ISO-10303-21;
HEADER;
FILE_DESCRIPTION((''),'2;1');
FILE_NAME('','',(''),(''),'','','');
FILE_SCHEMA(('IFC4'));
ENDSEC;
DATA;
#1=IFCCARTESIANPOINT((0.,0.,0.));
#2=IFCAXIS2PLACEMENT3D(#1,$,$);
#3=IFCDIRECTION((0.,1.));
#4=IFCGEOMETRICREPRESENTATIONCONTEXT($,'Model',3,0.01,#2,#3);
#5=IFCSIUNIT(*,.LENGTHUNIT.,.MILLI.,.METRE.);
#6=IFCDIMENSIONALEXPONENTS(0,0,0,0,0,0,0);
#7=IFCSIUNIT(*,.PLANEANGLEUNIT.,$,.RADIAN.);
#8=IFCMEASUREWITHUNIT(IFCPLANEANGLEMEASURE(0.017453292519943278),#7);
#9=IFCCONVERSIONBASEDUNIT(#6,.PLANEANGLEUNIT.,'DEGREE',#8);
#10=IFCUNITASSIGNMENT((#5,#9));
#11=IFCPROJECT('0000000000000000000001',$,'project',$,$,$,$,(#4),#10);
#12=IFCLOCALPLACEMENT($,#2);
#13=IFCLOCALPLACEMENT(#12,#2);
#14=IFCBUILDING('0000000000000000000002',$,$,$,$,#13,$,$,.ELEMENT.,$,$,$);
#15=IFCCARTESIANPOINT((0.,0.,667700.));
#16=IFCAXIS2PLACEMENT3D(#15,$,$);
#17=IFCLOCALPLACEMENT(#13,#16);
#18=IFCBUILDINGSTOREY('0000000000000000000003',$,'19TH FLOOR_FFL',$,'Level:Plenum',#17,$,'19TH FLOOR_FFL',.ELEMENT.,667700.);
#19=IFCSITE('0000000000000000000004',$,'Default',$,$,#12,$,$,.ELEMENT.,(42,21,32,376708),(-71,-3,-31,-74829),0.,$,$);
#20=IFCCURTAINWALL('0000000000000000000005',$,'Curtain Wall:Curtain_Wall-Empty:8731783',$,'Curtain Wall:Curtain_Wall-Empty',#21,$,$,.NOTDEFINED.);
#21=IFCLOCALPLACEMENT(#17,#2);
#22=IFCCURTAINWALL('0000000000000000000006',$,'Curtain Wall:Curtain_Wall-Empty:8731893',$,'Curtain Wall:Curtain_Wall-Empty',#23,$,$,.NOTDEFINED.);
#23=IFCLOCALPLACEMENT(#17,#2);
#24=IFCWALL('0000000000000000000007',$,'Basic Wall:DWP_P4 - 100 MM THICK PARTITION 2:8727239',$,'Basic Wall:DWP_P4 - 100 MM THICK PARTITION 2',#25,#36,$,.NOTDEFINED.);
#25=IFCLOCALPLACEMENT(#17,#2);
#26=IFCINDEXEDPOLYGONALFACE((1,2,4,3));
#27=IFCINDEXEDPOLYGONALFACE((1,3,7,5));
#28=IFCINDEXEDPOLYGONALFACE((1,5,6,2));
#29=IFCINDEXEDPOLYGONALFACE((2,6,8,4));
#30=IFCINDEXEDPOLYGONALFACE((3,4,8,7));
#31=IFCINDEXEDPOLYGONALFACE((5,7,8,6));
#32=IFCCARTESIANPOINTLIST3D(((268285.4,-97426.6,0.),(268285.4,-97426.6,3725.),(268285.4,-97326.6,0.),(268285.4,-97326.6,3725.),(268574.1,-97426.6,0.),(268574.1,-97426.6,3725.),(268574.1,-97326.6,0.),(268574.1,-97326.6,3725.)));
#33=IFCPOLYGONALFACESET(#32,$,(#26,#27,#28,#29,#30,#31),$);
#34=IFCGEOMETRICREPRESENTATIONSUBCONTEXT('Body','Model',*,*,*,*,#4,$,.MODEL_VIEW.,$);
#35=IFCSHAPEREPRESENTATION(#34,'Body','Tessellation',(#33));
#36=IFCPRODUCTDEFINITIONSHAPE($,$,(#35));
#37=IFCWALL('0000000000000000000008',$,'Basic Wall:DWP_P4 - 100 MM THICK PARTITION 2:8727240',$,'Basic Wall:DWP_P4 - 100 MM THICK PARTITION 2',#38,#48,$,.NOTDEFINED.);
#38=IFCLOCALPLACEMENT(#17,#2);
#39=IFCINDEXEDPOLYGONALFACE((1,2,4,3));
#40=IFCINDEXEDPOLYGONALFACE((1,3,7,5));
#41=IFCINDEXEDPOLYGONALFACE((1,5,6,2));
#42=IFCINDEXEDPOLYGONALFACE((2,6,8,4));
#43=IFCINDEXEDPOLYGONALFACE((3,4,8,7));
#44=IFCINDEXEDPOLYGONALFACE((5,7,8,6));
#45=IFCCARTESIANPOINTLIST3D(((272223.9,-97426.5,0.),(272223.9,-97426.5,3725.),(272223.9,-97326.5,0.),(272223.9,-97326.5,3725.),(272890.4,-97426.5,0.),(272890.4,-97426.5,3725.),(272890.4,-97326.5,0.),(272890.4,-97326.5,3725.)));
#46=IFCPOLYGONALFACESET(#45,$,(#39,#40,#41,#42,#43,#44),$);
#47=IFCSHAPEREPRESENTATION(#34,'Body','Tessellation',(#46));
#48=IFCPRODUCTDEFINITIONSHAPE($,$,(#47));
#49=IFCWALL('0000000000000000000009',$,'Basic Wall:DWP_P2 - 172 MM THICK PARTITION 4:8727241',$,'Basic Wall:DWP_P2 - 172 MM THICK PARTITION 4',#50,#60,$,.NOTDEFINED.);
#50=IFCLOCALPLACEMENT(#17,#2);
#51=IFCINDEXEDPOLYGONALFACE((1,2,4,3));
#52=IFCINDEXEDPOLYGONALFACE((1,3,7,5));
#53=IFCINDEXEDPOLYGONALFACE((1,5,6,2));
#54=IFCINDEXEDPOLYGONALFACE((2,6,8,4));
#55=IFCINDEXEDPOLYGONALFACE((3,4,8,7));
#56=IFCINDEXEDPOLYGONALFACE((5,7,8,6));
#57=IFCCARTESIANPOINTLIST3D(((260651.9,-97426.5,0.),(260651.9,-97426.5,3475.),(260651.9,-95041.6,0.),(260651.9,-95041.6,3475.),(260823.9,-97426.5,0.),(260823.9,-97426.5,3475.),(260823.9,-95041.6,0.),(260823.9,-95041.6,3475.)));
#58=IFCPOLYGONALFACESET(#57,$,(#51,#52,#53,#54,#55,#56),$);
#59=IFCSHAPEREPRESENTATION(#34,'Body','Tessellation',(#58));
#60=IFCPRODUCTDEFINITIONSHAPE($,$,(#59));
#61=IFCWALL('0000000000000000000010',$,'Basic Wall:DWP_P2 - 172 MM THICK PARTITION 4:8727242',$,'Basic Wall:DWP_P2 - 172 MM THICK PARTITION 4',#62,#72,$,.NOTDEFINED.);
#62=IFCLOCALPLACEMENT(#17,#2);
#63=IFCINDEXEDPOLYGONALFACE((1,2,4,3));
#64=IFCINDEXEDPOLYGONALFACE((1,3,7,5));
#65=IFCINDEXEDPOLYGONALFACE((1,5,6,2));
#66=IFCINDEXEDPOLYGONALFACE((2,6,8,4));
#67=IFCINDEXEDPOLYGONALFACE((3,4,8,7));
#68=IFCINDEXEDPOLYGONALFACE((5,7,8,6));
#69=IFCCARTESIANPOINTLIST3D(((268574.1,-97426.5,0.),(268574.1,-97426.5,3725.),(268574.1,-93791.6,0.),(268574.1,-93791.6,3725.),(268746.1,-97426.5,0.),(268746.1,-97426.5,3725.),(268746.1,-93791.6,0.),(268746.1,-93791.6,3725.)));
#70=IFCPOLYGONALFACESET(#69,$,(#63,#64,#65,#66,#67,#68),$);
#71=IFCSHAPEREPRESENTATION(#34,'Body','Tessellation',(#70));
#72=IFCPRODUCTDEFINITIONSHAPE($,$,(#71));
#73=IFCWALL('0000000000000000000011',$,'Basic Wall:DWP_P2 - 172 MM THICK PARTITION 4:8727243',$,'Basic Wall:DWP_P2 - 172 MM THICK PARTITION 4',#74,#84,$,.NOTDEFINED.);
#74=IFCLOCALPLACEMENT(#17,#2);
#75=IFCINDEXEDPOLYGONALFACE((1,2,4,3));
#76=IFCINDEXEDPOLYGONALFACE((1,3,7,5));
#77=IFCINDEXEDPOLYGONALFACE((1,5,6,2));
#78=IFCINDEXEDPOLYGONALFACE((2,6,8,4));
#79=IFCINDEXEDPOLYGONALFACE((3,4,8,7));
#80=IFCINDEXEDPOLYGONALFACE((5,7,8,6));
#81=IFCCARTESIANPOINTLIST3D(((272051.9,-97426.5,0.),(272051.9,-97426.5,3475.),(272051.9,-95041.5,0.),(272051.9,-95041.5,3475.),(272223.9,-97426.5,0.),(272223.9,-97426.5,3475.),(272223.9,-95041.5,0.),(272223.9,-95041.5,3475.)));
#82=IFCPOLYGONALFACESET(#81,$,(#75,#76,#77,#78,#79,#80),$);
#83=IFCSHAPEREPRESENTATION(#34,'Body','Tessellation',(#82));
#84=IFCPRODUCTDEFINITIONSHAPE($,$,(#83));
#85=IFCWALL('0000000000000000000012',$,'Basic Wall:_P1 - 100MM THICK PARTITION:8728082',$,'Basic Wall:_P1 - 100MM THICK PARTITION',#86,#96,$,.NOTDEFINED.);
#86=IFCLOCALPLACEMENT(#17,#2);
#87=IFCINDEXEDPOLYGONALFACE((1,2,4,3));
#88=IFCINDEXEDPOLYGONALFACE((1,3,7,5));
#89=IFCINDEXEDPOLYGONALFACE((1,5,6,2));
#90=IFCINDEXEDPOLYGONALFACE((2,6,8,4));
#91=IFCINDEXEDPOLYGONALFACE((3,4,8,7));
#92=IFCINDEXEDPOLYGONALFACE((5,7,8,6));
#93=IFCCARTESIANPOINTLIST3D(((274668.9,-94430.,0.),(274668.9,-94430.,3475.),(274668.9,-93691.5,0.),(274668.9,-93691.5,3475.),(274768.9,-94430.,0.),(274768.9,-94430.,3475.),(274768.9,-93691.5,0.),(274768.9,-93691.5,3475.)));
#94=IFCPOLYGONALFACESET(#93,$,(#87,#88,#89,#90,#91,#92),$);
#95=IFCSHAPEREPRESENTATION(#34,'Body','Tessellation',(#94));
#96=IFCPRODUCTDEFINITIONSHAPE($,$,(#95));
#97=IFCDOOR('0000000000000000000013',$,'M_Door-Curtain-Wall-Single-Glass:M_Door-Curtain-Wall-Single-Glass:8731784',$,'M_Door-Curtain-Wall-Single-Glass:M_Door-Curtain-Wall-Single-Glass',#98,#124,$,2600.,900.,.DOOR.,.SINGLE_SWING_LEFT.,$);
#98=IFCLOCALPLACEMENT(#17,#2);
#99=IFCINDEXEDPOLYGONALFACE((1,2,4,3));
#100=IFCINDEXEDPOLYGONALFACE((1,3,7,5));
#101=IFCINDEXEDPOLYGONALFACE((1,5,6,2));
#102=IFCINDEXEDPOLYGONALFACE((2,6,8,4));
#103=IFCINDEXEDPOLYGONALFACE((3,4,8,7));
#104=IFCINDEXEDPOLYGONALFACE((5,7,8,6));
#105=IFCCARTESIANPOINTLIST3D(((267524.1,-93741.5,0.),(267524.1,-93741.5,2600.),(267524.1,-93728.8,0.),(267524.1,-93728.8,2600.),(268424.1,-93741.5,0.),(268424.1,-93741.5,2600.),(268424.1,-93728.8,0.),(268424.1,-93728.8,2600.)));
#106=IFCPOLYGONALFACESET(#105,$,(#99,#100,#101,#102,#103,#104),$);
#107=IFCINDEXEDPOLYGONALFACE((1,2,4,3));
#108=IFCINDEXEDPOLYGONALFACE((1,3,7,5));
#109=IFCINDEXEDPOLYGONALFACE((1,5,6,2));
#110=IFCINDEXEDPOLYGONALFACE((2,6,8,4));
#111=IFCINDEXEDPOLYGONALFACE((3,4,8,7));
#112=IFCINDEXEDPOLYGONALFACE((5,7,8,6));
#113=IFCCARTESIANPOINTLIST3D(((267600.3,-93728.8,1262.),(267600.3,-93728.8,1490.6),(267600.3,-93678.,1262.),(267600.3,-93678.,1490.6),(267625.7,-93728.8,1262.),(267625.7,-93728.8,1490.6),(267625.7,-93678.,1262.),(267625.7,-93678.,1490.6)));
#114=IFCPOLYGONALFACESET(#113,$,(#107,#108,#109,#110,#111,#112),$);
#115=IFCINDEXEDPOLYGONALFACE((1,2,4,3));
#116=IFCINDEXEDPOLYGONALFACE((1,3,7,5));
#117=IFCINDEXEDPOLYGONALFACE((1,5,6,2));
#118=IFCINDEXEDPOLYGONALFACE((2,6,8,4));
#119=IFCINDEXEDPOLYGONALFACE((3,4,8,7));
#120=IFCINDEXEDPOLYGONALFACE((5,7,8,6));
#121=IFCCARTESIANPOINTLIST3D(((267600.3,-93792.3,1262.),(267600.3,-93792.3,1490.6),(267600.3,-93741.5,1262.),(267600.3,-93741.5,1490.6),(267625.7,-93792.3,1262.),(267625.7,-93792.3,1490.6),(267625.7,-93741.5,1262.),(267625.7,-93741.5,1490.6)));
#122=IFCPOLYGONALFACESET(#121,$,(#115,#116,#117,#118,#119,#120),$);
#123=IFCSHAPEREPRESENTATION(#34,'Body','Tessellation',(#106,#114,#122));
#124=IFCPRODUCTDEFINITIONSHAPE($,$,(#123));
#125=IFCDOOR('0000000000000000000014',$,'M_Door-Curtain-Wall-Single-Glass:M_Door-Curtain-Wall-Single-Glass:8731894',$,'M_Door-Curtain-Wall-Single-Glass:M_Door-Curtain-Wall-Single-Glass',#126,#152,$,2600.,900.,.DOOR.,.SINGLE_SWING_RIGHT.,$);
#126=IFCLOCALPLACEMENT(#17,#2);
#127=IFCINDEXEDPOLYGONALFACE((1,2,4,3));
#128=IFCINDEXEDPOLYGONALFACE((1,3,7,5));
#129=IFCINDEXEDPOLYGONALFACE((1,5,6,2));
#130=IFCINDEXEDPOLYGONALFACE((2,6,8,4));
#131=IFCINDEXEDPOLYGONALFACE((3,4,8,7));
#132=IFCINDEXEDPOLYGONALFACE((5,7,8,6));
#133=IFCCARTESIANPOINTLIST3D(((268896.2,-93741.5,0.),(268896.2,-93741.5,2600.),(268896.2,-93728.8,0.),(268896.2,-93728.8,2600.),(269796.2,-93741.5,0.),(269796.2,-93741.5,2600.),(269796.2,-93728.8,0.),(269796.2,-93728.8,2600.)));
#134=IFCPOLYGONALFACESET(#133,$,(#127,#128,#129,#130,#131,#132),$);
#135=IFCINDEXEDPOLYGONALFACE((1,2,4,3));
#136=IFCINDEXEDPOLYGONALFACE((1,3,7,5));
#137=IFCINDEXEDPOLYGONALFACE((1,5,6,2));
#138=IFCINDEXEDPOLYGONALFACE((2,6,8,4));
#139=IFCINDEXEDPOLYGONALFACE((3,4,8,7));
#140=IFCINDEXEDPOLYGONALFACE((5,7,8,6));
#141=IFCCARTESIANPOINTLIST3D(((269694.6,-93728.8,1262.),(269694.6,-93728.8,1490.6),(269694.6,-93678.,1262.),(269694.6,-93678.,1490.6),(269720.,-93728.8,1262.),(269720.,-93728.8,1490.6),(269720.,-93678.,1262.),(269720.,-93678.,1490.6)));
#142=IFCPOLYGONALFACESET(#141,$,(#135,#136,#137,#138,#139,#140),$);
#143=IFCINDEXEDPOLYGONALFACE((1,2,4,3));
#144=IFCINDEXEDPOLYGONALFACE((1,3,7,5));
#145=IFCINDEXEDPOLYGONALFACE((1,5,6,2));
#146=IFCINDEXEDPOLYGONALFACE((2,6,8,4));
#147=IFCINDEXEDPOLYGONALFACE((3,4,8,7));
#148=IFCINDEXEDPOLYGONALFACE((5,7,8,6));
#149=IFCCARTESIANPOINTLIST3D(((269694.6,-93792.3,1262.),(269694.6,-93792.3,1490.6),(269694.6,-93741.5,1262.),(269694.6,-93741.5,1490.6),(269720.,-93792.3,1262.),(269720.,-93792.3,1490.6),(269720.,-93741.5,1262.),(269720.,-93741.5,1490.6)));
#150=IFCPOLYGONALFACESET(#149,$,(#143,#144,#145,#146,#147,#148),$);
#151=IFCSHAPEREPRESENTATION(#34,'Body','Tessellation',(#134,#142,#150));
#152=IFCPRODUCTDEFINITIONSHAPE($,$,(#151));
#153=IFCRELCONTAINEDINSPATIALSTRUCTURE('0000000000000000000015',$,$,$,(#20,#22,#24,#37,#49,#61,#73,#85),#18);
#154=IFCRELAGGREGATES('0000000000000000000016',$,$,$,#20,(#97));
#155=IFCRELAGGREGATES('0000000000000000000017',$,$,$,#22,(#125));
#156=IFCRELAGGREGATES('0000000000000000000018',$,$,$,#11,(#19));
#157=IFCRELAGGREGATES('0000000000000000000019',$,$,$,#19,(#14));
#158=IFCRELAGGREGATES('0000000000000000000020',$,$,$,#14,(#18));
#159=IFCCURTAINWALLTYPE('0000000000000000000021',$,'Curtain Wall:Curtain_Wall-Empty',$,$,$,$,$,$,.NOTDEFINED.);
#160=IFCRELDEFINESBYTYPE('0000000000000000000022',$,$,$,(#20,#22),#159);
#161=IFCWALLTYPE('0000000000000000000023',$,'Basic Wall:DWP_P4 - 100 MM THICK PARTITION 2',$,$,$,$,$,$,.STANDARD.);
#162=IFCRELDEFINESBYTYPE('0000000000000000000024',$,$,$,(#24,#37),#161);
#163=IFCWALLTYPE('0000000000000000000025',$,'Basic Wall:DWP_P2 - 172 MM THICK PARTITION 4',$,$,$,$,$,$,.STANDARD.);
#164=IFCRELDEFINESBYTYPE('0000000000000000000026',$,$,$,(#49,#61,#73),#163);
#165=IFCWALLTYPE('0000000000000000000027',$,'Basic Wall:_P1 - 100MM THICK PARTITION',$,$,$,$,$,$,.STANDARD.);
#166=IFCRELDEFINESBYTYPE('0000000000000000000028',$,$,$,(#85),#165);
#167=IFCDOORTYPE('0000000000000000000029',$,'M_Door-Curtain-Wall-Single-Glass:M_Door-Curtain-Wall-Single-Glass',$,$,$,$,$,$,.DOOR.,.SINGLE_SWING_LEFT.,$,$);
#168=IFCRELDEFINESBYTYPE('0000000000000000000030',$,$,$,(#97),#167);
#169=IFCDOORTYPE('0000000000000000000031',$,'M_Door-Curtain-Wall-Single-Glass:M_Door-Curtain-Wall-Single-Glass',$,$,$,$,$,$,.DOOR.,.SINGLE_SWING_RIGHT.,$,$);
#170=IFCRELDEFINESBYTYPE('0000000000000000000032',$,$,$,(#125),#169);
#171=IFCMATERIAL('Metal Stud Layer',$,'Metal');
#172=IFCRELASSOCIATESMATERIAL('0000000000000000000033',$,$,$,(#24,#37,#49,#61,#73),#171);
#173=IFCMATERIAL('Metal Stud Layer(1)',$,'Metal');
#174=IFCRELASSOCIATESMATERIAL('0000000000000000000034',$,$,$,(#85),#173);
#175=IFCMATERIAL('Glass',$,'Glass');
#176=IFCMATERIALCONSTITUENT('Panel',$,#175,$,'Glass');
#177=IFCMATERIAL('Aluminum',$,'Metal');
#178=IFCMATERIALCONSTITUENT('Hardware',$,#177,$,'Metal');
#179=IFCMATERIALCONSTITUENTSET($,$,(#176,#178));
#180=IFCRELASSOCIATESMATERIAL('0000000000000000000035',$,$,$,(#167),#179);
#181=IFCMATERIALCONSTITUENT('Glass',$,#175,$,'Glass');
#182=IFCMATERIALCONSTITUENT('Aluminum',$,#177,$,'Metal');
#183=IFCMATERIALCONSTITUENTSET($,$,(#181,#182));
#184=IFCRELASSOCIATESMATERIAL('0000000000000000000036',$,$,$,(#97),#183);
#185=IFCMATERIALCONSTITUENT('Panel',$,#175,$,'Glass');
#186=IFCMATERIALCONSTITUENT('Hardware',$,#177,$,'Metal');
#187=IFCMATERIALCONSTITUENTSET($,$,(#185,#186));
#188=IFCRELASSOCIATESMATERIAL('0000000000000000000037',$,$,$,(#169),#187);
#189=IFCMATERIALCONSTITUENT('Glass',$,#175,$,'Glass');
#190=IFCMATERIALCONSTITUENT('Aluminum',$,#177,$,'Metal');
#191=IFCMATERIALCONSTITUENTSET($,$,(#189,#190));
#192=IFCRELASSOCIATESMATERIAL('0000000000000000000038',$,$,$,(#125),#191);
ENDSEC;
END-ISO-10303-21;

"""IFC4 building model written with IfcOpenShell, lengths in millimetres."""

from ifc_helpers import new_model, entity, si_unit, converted_unit, direction, frame, origin, place, context, subcontext, project, spatial, indexed_curve, outline, extrude, source, transform, mapped, material, constituent, constituent_set, type_object, type_shapes, element, aggregate, save


model = new_model("IFC4")

# Units and contexts
model_context = context("Model", 3, precision=0.01, world=origin(), true_north=direction((0.0, 1.0)))
body_context = subcontext(model_context, "Body", "Model", "MODEL_VIEW")
ifc_project = project(units=[si_unit("LENGTHUNIT", "METRE", prefix="MILLI"), converted_unit("PLANEANGLEUNIT", "DEGREE", entity("IfcPlaneAngleMeasure", 0.017453292519943278), si_unit("PLANEANGLEUNIT", "RADIAN"), dimensions=[0, 0, 0, 0, 0, 0, 0])], contexts=[model_context])

# Site, building, storey
site_placement = place(None, origin())
site = spatial("IfcSite", under=ifc_project, at=site_placement, Name="Default", CompositionType="ELEMENT", RefLatitude=(42, 21, 32, 376708), RefLongitude=(-71, -3, -31, -74829), RefElevation=0.0)
building_placement = place(site_placement, origin())
building = spatial("IfcBuilding", under=site, at=building_placement, CompositionType="ELEMENT")
storey_placement = place(building_placement, frame((0.0, 0.0, 667700.0)))
storey = spatial("IfcBuildingStorey", under=building, at=storey_placement, Name="19TH FLOOR_FFL", ObjectType="Level:Plenum", LongName="19TH FLOOR_FFL", CompositionType="ELEMENT", Elevation=667700.0)

# Curtain walls
curtain_wall_type = type_object("IfcCurtainWallType", Name="Curtain Wall:Curtain_Wall-Empty", PredefinedType="NOTDEFINED")
curtain_wall_1_placement = place(storey_placement, frame((0.0, 0.0, -667700.0)))
curtain_wall_1 = element("IfcCurtainWall", 1, at=curtain_wall_1_placement, inside=storey, type_object=curtain_wall_type, Name="Curtain Wall:Curtain_Wall-Empty:8731783", ObjectType="Curtain Wall:Curtain_Wall-Empty", PredefinedType="NOTDEFINED")
curtain_wall_2_placement = place(storey_placement, frame((0.0, 0.0, -667700.0)))
curtain_wall_2 = element("IfcCurtainWall", 2, at=curtain_wall_2_placement, inside=storey, type_object=curtain_wall_type, Name="Curtain Wall:Curtain_Wall-Empty:8731893", ObjectType="Curtain Wall:Curtain_Wall-Empty", PredefinedType="NOTDEFINED")

# Walls
ifc_material_1 = material(Name="Metal Stud Layer", Category="Metal")
wall_type_1 = type_object("IfcWallType", Name="Basic Wall:DWP_P4 - 100 MM THICK PARTITION 2", PredefinedType="STANDARD")
wall_1_placement = place(storey_placement, frame((268285.4, -97376.6, 0.0)))
element("IfcWall", 3, at=wall_1_placement, inside=storey, type_object=wall_type_1, material=ifc_material_1, Name="Basic Wall:DWP_P4 - 100 MM THICK PARTITION 2:8727239", ObjectType="Basic Wall:DWP_P4 - 100 MM THICK PARTITION 2", PredefinedType="NOTDEFINED", context=body_context, shape_type="SweptSolid", body=[
    extrude(outline(indexed_curve([(288.7, 50.0), (0.0, 50.0), (0.0, -50.0), (288.7, -50.0), (288.7, 50.0)], self_intersect=False)), origin(), (0.0, 0.0, 1.0), 3725.0),
])
wall_2_placement = place(storey_placement, frame((272223.9, -97376.5, 0.0)))
element("IfcWall", 4, at=wall_2_placement, inside=storey, type_object=wall_type_1, material=ifc_material_1, Name="Basic Wall:DWP_P4 - 100 MM THICK PARTITION 2:8727240", ObjectType="Basic Wall:DWP_P4 - 100 MM THICK PARTITION 2", PredefinedType="NOTDEFINED", context=body_context, shape_type="SweptSolid", body=[
    extrude(outline(indexed_curve([(666.5, 50.0), (0.0, 50.0), (0.0, -50.0), (666.5, -50.0), (666.5, 50.0)], self_intersect=False)), origin(), (0.0, 0.0, 1.0), 3725.0),
])
wall_type_2 = type_object("IfcWallType", Name="Basic Wall:DWP_P2 - 172 MM THICK PARTITION 4", PredefinedType="STANDARD")
wall_3_placement = place(storey_placement, frame((260737.9, -97426.5, 0.0), z_axis=(0.0, 0.0, 1.0), x_axis=(0.0, 1.0, 0.0)))
element("IfcWall", 5, at=wall_3_placement, inside=storey, type_object=wall_type_2, material=ifc_material_1, Name="Basic Wall:DWP_P2 - 172 MM THICK PARTITION 4:8727241", ObjectType="Basic Wall:DWP_P2 - 172 MM THICK PARTITION 4", PredefinedType="NOTDEFINED", context=body_context, shape_type="SweptSolid", body=[
    extrude(outline(indexed_curve([(2384.8, 86.0), (0.0, 86.0), (0.0, -86.0), (2384.8, -86.0), (2384.8, 86.0)], self_intersect=False)), origin(), (0.0, 0.0, 1.0), 3475.0),
])
wall_4_placement = place(storey_placement, frame((268660.1, -97426.5, 0.0), z_axis=(0.0, 0.0, 1.0), x_axis=(0.0, 1.0, 0.0)))
element("IfcWall", 6, at=wall_4_placement, inside=storey, type_object=wall_type_2, material=ifc_material_1, Name="Basic Wall:DWP_P2 - 172 MM THICK PARTITION 4:8727242", ObjectType="Basic Wall:DWP_P2 - 172 MM THICK PARTITION 4", PredefinedType="NOTDEFINED", context=body_context, shape_type="SweptSolid", body=[
    extrude(outline(indexed_curve([(3634.8, 86.0), (0.0, 86.0), (0.0, -86.0), (3634.8, -86.0), (3634.8, 86.0)], self_intersect=False)), origin(), (0.0, 0.0, 1.0), 3725.0),
])
wall_5_placement = place(storey_placement, frame((272137.9, -97426.5, 0.0), z_axis=(0.0, 0.0, 1.0), x_axis=(0.0, 1.0, 0.0)))
element("IfcWall", 7, at=wall_5_placement, inside=storey, type_object=wall_type_2, material=ifc_material_1, Name="Basic Wall:DWP_P2 - 172 MM THICK PARTITION 4:8727243", ObjectType="Basic Wall:DWP_P2 - 172 MM THICK PARTITION 4", PredefinedType="NOTDEFINED", context=body_context, shape_type="SweptSolid", body=[
    extrude(outline(indexed_curve([(2385.0, 86.0), (0.0, 86.0), (0.0, -86.0), (2385.0, -86.0), (2385.0, 86.0)], self_intersect=False)), origin(), (0.0, 0.0, 1.0), 3475.0),
])
ifc_material_2 = material(Name="Metal Stud Layer(1)", Category="Metal")
wall_type_3 = type_object("IfcWallType", Name="Basic Wall:_P1 - 100MM THICK PARTITION", PredefinedType="STANDARD")
wall_6_placement = place(storey_placement, frame((274718.9, -94430.0, 0.0), z_axis=(0.0, 0.0, 1.0), x_axis=(0.0, 1.0, 0.0)))
element("IfcWall", 8, at=wall_6_placement, inside=storey, type_object=wall_type_3, material=ifc_material_2, Name="Basic Wall:_P1 - 100MM THICK PARTITION:8728082", ObjectType="Basic Wall:_P1 - 100MM THICK PARTITION", PredefinedType="NOTDEFINED", context=body_context, shape_type="SweptSolid", body=[
    extrude(outline(indexed_curve([(738.5, 50.0), (0.0, 50.0), (0.0, -50.0), (738.5, -50.0), (738.5, 50.0)], self_intersect=False)), origin(), (0.0, 0.0, 1.0), 3475.0),
])

# Doors
ifc_material_3 = material(Name="Glass", Category="Glass")
ifc_constituent_1 = constituent(ifc_material_3, Name="Glass", Category="Glass")
ifc_material_4 = material(Name="Aluminum", Category="Metal")
ifc_constituent_2 = constituent(ifc_material_4, Name="Aluminum", Category="Metal")
ifc_constituent_set_1 = constituent_set(constituents=[ifc_constituent_1, ifc_constituent_2])
ifc_constituent_3 = constituent(ifc_material_3, Name="Panel", Category="Glass")
ifc_constituent_4 = constituent(ifc_material_4, Name="Hardware", Category="Metal")
ifc_constituent_set_2 = constituent_set(constituents=[ifc_constituent_3, ifc_constituent_4])
door_type_1 = type_object("IfcDoorType", Name="M_Door-Curtain-Wall-Single-Glass:M_Door-Curtain-Wall-Single-Glass", OperationType="SINGLE_SWING_LEFT", PredefinedType="DOOR", material=ifc_constituent_set_2)
shared_shape_1 = source(origin(), body_context, "Body", "SweptSolid", [
    extrude(outline(indexed_curve([(-6.4, -450.0), (6.4, -450.0), (6.4, 450.0), (-6.4, 450.0), (-6.4, -450.0)], self_intersect=False)), frame((0.0, -6.3, 0.0), z_axis=(0.0, 0.0, 1.0), x_axis=(0.0, -1.0, 0.0)), (0.0, 0.0, 1.0), 2600.0),
    extrude(outline(indexed_curve([(-12.7, -25.4), (12.7, -25.4), (12.7, 25.4), (-12.7, 25.4), (-12.7, -25.4)], self_intersect=False)), frame((361.1, -38.1, 1262.0)), (0.0, 0.0, 1.0), 228.6),
    extrude(outline(indexed_curve([(-12.7, -25.4), (12.7, -25.4), (12.7, 25.4), (-12.7, 25.4), (-12.7, -25.4)], self_intersect=False)), frame((361.1, 25.4, 1262.0), z_axis=(0.0, 0.0, 1.0), x_axis=(-1.0, 0.0, 0.0)), (0.0, 0.0, 1.0), 228.6),
])
type_shapes(door_type_1, [shared_shape_1])
door_1_placement = place(curtain_wall_1_placement, frame((267974.1, -93741.5, 667700.0), z_axis=(0.0, 0.0, 1.0), x_axis=(-1.0, 0.0, 0.0)))
door_1 = element("IfcDoor", 9, at=door_1_placement, type_object=door_type_1, material=ifc_constituent_set_1, Name="M_Door-Curtain-Wall-Single-Glass:M_Door-Curtain-Wall-Single-Glass:8731784", ObjectType="M_Door-Curtain-Wall-Single-Glass:M_Door-Curtain-Wall-Single-Glass", OperationType="SINGLE_SWING_LEFT", OverallHeight=2600.0, OverallWidth=900.0, PredefinedType="DOOR", context=body_context, shape_type="MappedRepresentation", body=[
    mapped(shared_shape_1, transform((0.0, 0.0, 0.0), scale=1.0)),
])
aggregate(curtain_wall_1, [door_1])
ifc_constituent_5 = constituent(ifc_material_3, Name="Glass", Category="Glass")
ifc_constituent_6 = constituent(ifc_material_4, Name="Aluminum", Category="Metal")
ifc_constituent_set_3 = constituent_set(constituents=[ifc_constituent_5, ifc_constituent_6])
ifc_constituent_7 = constituent(ifc_material_3, Name="Panel", Category="Glass")
ifc_constituent_8 = constituent(ifc_material_4, Name="Hardware", Category="Metal")
ifc_constituent_set_4 = constituent_set(constituents=[ifc_constituent_7, ifc_constituent_8])
door_type_2 = type_object("IfcDoorType", Name="M_Door-Curtain-Wall-Single-Glass:M_Door-Curtain-Wall-Single-Glass", OperationType="SINGLE_SWING_RIGHT", PredefinedType="DOOR", material=ifc_constituent_set_4)
shared_shape_2 = source(origin(), body_context, "Body", "SweptSolid", [
    extrude(outline(indexed_curve([(-450.0, -6.4), (450.0, -6.4), (450.0, 6.4), (-450.0, 6.4), (-450.0, -6.4)], self_intersect=False)), frame((0.0, -6.3, 0.0), z_axis=(0.0, 0.0, 1.0), x_axis=(-1.0, 0.0, 0.0)), (0.0, 0.0, 1.0), 2600.0),
    extrude(outline(indexed_curve([(-25.4, -12.7), (25.4, -12.7), (25.4, 12.7), (-25.4, 12.7), (-25.4, -12.7)], self_intersect=False)), frame((-361.1, -38.1, 1262.0), z_axis=(0.0, 0.0, 1.0), x_axis=(0.0, 1.0, 0.0)), (0.0, 0.0, 1.0), 228.6),
    extrude(outline(indexed_curve([(-25.4, -12.7), (25.4, -12.7), (25.4, 12.7), (-25.4, 12.7), (-25.4, -12.7)], self_intersect=False)), frame((-361.1, 25.4, 1262.0), z_axis=(0.0, 0.0, 1.0), x_axis=(0.0, -1.0, 0.0)), (0.0, 0.0, 1.0), 228.6),
])
type_shapes(door_type_2, [shared_shape_2])
door_2_placement = place(curtain_wall_2_placement, frame((269346.2, -93741.5, 667700.0), z_axis=(0.0, 0.0, 1.0), x_axis=(-1.0, 0.0, 0.0)))
door_2 = element("IfcDoor", 10, at=door_2_placement, type_object=door_type_2, material=ifc_constituent_set_3, Name="M_Door-Curtain-Wall-Single-Glass:M_Door-Curtain-Wall-Single-Glass:8731894", ObjectType="M_Door-Curtain-Wall-Single-Glass:M_Door-Curtain-Wall-Single-Glass", OperationType="SINGLE_SWING_RIGHT", OverallHeight=2600.0, OverallWidth=900.0, PredefinedType="DOOR", context=body_context, shape_type="MappedRepresentation", body=[
    mapped(shared_shape_2, transform((0.0, 0.0, 0.0), scale=1.0)),
])
aggregate(curtain_wall_2, [door_2])

save(model, "model.ifc")
